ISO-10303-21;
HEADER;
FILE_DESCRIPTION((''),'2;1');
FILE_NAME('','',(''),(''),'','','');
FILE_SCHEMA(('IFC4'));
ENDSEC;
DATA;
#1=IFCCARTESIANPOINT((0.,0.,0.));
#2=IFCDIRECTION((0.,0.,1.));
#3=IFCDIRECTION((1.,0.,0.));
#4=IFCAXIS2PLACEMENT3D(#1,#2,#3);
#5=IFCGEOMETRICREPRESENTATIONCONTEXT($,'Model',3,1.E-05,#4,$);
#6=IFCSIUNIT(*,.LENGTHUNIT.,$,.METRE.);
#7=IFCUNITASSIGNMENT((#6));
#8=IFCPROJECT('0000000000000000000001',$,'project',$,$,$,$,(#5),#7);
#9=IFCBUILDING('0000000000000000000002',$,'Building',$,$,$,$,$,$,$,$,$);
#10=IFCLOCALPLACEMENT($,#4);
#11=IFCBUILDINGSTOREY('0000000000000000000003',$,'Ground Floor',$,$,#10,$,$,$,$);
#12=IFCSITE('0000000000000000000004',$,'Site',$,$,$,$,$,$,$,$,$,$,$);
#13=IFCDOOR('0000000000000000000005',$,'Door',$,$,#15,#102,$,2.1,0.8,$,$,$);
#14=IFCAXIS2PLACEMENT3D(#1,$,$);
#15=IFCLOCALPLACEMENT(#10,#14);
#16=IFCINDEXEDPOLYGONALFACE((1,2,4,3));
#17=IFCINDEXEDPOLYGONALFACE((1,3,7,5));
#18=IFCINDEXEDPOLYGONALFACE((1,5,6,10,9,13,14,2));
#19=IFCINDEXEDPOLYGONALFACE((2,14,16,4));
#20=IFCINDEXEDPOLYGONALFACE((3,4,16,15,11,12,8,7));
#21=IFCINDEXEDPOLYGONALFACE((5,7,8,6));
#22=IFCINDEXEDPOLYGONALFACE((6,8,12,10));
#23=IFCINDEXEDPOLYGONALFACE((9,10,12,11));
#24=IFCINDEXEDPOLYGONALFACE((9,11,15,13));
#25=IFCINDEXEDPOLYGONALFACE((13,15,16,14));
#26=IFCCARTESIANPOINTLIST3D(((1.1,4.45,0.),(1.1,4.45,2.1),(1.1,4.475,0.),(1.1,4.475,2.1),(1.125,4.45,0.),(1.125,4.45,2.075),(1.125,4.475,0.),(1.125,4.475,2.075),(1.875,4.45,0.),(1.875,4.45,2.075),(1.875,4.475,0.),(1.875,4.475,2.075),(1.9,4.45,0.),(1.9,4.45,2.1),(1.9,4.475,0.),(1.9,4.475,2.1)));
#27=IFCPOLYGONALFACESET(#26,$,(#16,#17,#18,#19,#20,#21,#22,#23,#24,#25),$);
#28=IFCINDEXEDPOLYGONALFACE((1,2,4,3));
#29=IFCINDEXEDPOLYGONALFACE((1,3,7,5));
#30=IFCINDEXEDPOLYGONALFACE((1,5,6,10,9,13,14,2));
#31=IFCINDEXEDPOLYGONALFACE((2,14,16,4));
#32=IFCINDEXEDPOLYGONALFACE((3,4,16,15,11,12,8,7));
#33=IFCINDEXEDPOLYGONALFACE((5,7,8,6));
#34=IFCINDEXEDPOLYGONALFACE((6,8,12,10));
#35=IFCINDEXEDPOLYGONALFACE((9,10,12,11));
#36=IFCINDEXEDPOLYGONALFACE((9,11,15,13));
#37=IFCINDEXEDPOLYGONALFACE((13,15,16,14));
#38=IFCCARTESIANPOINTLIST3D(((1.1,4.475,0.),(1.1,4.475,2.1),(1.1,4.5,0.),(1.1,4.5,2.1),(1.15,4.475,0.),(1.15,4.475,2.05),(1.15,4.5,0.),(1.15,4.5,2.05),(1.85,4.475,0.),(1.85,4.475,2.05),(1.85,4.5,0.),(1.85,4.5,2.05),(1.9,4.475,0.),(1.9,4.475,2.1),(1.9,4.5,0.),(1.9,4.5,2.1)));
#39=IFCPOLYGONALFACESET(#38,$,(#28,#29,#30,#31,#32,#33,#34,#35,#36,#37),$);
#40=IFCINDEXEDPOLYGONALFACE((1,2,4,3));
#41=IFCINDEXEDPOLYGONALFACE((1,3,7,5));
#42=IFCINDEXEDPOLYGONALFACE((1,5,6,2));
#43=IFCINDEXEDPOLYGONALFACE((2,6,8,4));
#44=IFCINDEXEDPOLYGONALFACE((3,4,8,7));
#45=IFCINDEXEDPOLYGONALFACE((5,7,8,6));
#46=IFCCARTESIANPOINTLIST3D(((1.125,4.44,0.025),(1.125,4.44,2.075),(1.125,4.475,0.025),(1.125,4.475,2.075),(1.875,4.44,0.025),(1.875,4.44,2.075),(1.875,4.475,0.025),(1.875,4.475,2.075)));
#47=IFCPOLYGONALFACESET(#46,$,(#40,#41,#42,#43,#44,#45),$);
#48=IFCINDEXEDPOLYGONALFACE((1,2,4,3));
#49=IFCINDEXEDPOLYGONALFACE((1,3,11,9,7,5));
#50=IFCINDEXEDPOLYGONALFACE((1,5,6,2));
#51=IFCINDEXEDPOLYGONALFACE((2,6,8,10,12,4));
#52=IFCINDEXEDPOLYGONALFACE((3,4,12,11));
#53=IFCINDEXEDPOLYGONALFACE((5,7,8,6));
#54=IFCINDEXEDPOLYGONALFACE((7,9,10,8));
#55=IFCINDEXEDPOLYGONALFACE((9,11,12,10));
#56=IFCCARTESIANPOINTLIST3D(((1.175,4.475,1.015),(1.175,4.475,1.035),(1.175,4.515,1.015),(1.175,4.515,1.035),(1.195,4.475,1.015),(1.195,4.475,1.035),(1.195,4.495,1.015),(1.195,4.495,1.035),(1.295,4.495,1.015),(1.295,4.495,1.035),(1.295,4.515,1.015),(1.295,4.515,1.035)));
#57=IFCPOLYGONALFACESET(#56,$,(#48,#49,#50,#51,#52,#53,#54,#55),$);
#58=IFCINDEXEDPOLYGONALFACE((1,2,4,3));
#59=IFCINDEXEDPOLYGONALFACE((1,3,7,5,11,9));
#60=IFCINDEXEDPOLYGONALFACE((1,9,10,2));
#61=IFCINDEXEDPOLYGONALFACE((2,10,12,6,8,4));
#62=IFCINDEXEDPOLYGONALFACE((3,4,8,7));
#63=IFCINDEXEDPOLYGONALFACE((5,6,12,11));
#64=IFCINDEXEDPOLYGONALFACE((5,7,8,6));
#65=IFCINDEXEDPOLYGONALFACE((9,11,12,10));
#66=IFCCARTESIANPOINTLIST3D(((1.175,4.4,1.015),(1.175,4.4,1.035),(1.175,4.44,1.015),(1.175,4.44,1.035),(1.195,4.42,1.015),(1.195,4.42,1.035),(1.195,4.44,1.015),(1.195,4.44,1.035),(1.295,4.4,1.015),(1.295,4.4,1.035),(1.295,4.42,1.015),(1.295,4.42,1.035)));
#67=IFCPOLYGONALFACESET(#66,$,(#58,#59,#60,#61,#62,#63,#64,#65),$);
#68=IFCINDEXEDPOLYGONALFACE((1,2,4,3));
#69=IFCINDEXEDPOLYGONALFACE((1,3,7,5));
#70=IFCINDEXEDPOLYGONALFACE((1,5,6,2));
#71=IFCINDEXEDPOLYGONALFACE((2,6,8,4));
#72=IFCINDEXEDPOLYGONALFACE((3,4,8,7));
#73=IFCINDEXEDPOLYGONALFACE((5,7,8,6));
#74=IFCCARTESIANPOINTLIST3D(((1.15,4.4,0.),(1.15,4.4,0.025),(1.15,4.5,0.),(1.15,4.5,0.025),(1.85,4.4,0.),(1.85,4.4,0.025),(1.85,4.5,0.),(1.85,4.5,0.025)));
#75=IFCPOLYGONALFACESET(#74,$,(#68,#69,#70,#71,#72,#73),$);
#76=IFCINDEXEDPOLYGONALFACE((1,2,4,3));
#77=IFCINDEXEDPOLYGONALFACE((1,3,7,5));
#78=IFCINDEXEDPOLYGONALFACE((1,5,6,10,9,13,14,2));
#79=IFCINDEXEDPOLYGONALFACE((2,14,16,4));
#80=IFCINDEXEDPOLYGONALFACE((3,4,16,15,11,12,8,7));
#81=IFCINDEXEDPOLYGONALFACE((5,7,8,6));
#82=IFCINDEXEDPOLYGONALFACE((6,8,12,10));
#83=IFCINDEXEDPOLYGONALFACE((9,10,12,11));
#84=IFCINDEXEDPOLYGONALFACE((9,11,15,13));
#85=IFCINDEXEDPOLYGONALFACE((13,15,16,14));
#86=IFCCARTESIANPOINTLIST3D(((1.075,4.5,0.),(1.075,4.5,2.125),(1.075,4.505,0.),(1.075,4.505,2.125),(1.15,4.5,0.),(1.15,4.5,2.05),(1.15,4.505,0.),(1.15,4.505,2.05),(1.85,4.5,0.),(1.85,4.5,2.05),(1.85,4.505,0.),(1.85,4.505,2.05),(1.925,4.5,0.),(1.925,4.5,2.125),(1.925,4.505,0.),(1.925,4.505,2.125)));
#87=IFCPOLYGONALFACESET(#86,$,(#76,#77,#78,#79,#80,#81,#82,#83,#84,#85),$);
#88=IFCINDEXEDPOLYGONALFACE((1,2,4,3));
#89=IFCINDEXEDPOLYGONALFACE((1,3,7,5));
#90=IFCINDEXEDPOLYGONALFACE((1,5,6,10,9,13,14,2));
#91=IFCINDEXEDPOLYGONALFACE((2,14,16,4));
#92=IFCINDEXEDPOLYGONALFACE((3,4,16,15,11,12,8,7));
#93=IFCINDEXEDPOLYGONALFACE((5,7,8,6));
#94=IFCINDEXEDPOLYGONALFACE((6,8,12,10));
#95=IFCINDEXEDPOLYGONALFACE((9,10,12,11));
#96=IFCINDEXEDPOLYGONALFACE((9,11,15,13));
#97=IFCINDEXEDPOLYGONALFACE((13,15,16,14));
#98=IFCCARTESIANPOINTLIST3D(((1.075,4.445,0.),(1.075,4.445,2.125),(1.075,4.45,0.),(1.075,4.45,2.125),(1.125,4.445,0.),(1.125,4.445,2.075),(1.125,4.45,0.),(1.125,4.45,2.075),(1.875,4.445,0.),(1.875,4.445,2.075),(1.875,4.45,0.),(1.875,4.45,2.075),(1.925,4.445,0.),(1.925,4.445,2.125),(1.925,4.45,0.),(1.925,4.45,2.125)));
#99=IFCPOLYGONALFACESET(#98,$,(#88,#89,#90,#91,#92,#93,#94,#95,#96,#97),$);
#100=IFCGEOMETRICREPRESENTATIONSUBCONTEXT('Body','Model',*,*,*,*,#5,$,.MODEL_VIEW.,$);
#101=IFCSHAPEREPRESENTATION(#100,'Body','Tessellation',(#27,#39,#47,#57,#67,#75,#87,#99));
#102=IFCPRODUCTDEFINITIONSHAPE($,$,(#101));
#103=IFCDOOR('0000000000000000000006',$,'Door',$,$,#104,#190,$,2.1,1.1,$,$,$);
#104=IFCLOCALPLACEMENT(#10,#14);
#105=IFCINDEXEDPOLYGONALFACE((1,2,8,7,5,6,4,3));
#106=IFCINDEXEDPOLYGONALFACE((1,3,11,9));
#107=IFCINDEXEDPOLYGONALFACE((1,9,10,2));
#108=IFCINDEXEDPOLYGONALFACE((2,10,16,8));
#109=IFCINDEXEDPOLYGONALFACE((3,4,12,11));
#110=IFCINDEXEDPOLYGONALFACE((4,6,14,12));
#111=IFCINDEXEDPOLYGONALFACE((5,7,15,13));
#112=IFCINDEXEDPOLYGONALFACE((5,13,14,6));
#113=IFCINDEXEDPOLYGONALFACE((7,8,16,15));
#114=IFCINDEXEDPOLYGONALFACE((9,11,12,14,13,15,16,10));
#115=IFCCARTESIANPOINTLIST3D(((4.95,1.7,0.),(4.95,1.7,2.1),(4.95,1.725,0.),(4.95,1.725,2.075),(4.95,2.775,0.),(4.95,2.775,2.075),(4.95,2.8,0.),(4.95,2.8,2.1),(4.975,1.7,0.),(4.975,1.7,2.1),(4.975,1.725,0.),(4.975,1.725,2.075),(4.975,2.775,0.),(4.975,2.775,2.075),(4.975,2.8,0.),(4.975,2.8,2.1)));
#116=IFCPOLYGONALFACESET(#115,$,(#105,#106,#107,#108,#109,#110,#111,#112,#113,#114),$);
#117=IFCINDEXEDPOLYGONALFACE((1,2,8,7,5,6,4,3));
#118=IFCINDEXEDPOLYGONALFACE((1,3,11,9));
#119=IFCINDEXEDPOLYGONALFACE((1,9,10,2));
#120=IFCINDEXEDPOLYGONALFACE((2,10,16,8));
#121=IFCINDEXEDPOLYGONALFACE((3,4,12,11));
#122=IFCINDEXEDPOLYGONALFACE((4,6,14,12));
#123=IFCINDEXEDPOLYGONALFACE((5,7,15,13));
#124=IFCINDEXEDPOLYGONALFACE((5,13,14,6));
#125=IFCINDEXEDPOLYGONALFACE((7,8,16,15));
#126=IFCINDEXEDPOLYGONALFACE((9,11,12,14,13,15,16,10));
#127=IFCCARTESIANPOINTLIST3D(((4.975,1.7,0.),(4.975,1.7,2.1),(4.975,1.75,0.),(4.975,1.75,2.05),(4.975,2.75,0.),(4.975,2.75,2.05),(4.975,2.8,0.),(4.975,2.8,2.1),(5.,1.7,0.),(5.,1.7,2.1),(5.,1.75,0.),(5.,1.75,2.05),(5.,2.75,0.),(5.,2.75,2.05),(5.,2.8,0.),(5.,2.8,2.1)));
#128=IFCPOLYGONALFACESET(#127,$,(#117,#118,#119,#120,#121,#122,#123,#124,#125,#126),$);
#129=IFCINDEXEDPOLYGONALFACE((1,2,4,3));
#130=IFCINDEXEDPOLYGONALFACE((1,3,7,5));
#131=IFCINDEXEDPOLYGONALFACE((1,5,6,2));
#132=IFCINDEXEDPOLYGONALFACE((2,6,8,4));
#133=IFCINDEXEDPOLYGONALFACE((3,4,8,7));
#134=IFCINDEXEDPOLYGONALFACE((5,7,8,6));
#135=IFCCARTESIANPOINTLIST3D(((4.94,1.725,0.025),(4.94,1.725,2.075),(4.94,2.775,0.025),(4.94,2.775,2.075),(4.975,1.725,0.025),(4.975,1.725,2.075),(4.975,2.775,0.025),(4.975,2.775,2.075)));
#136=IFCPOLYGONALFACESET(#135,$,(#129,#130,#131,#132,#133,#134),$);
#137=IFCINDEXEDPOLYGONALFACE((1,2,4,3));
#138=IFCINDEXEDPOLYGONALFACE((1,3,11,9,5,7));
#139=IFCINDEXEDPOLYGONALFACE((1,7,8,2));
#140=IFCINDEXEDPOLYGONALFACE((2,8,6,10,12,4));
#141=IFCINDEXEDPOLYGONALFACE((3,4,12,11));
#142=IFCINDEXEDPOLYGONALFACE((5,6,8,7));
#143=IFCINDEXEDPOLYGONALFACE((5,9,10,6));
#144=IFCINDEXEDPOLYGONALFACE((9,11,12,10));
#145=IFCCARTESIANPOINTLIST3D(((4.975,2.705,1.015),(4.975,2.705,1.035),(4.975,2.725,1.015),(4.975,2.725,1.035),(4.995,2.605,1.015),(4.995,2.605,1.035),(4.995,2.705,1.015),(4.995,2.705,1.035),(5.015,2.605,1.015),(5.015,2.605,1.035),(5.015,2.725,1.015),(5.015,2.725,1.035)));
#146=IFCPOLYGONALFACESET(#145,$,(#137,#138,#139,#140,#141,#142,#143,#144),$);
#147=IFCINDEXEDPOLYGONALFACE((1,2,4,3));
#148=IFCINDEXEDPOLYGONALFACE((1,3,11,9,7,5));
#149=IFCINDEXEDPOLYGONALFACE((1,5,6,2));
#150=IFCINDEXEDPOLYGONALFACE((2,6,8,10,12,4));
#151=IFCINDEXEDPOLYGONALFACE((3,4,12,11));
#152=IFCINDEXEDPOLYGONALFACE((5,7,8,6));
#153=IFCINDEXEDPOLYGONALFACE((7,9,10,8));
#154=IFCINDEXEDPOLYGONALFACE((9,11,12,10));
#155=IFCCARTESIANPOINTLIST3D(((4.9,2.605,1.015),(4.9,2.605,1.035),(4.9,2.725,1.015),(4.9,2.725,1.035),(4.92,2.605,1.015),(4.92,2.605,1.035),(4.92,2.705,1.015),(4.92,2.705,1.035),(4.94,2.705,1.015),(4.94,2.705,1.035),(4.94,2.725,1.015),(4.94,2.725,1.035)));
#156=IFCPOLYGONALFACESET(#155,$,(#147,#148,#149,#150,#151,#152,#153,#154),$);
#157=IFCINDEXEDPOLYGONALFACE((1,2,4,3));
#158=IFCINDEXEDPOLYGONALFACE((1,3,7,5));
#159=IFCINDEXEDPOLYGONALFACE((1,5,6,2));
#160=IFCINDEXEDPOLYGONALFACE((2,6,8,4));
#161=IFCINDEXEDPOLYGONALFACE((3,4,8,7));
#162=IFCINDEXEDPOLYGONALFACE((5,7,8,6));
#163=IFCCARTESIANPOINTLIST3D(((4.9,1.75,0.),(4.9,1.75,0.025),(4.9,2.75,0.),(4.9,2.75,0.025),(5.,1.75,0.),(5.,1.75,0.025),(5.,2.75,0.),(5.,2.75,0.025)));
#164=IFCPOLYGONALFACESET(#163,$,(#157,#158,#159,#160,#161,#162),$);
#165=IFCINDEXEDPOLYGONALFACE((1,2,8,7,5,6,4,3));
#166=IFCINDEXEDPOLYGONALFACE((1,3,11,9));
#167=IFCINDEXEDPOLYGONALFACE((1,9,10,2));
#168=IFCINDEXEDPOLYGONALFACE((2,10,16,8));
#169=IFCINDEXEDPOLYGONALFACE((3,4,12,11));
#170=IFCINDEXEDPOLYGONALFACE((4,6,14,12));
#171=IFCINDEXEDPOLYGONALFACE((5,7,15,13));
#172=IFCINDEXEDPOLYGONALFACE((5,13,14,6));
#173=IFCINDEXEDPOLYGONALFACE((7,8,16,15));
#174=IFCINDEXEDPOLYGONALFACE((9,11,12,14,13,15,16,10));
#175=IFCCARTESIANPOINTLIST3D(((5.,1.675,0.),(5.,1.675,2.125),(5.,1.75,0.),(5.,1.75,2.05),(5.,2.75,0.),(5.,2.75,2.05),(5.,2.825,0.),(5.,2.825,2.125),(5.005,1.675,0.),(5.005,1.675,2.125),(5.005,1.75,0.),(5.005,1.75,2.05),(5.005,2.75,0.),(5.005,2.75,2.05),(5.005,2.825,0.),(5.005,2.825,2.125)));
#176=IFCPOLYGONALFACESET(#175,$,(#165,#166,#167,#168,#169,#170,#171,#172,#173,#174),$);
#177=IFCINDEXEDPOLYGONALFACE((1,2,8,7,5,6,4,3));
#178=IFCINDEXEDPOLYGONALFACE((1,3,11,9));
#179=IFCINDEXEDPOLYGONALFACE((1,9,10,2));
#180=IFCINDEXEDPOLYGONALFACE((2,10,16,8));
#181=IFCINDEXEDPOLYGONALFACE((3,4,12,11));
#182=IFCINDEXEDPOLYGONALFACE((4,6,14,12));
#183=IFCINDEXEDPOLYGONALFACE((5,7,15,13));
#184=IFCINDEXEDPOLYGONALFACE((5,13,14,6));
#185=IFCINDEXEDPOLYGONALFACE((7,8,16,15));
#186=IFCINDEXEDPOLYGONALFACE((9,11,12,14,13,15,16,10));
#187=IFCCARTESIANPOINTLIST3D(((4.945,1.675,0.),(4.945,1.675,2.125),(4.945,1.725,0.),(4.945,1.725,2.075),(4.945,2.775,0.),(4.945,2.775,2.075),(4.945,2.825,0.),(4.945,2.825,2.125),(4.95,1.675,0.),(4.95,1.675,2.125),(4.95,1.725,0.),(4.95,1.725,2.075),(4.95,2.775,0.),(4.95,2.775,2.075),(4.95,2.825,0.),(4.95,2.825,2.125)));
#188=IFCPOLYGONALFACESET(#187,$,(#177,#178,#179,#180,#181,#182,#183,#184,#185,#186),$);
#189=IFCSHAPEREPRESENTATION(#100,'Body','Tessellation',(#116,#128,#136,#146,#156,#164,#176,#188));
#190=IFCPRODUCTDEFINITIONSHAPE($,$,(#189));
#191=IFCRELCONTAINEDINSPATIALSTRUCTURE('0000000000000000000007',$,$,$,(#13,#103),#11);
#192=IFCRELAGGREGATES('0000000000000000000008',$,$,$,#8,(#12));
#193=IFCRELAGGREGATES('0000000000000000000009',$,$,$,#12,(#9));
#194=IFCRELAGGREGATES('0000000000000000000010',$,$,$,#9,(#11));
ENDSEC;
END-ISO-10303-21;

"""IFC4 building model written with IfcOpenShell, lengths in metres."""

from ifc_helpers import new_model, si_unit, frame, origin_with_axes, place, context, subcontext, project, spatial, line, indexed_curve, outline, extrude, element, save


model = new_model("IFC4")

# Units and contexts
model_context = context("Model", 3, precision=1e-05, world=origin_with_axes())
body_context = subcontext(model_context, "Body", "Model", "MODEL_VIEW")
ifc_project = project(units=[si_unit("LENGTHUNIT", "METRE")], contexts=[model_context])

# Site, building, storey
site = spatial("IfcSite", under=ifc_project, Name="Site")
building = spatial("IfcBuilding", under=site, Name="Building")
storey_placement = place(None, origin_with_axes())
storey = spatial("IfcBuildingStorey", under=building, at=storey_placement, Name="Ground Floor")

# Doors
door_1_placement = place(storey_placement, frame((1.9, 4.5, 0.0), z_axis=(0.0, 0.0, 1.0), x_axis=(-1.0, 0.0, 0.0)))
element("IfcDoor", 1, at=door_1_placement, inside=storey, Name="Door", OverallHeight=2.1, OverallWidth=0.8, context=body_context, shape_type="SweptSolid", body=[
    extrude(outline(indexed_curve([(0.0, 0.0), (0.0, 2.1), (0.8, 2.1), (0.8, 0.0), (0.775, 0.0), (0.775, 2.075), (0.025, 2.075), (0.025, 0.0)], segments=[line(1, 2, 3, 4, 5, 6, 7, 8, 1)])), frame((0.0, 0.025, 0.0), z_axis=(0.0, -1.0, 0.0), x_axis=(1.0, 0.0, 0.0)), (0.0, 0.0, -1.0), 0.025),
    extrude(outline(indexed_curve([(0.0, 0.0), (0.0, 2.1), (0.8, 2.1), (0.8, 0.0), (0.75, 0.0), (0.75, 2.05), (0.05, 2.05), (0.05, 0.0)], segments=[line(1, 2, 3, 4, 5, 6, 7, 8, 1)])), frame((0.0, 0.0, 0.0), z_axis=(0.0, -1.0, 0.0), x_axis=(1.0, 0.0, 0.0)), (0.0, 0.0, -1.0), 0.025),
    extrude(outline(indexed_curve([(0.0, 0.0), (0.75, 0.0), (0.75, 0.035), (0.0, 0.035)], segments=[line(1, 2, 3, 4, 1)])), frame((0.025, 0.025, 0.025), z_axis=(0.0, 0.0, 1.0), x_axis=(1.0, 0.0, 0.0)), (0.0, 0.0, 1.0), 2.05),
    extrude(outline(indexed_curve([(0.0, 0.0), (0.0, -0.04), (-0.12, -0.04), (-0.12, -0.02), (-0.02, -0.02), (-0.02, 0.0)], segments=[line(1, 2, 3, 4, 5, 6, 1)])), frame((0.725, 0.025, 1.015), z_axis=(0.0, 0.0, 1.0), x_axis=(1.0, 0.0, 0.0)), (0.0, 0.0, 1.0), 0.02),
    extrude(outline(indexed_curve([(0.0, 0.0), (0.0, 0.04), (-0.12, 0.04), (-0.12, 0.02), (-0.02, 0.02), (-0.02, 0.0)], segments=[line(1, 2, 3, 4, 5, 6, 1)])), frame((0.725, 0.06, 1.015), z_axis=(0.0, 0.0, 1.0), x_axis=(1.0, 0.0, 0.0)), (0.0, 0.0, 1.0), 0.02),
    extrude(outline(indexed_curve([(0.0, 0.0), (0.7, 0.0), (0.7, 0.1), (0.0, 0.1)], segments=[line(1, 2, 3, 4, 1)])), frame((0.05, 0.0, 0.0), z_axis=(0.0, 0.0, 1.0), x_axis=(1.0, 0.0, 0.0)), (0.0, 0.0, 1.0), 0.025),
    extrude(outline(indexed_curve([(0.0, 0.0), (0.0, 2.125), (0.85, 2.125), (0.85, 0.0), (0.775, 0.0), (0.775, 2.05), (0.075, 2.05), (0.075, 0.0)], segments=[line(1, 2, 3, 4, 5, 6, 7, 8, 1)])), frame((-0.025, -0.005, 0.0), z_axis=(0.0, -1.0, 0.0), x_axis=(1.0, 0.0, 0.0)), (0.0, 0.0, -1.0), 0.005),
    extrude(outline(indexed_curve([(0.0, 0.0), (0.0, 2.125), (0.85, 2.125), (0.85, 0.0), (0.8, 0.0), (0.8, 2.075), (0.05, 2.075), (0.05, 0.0)], segments=[line(1, 2, 3, 4, 5, 6, 7, 8, 1)])), frame((-0.025, 0.05, 0.0), z_axis=(0.0, -1.0, 0.0), x_axis=(1.0, 0.0, 0.0)), (0.0, 0.0, -1.0), 0.005),
])
door_2_placement = place(storey_placement, frame((5.0, 1.7, 0.0), z_axis=(0.0, 0.0, 1.0), x_axis=(0.0, 1.0, 0.0)))
element("IfcDoor", 2, at=door_2_placement, inside=storey, Name="Door", OverallHeight=2.1, OverallWidth=1.1, context=body_context, shape_type="SweptSolid", body=[
    extrude(outline(indexed_curve([(0.0, 0.0), (0.0, 2.1), (1.1, 2.1), (1.1, 0.0), (1.075, 0.0), (1.075, 2.075), (0.025, 2.075), (0.025, 0.0)], segments=[line(1, 2, 3, 4, 5, 6, 7, 8, 1)])), frame((0.0, 0.025, 0.0), z_axis=(0.0, -1.0, 0.0), x_axis=(1.0, 0.0, 0.0)), (0.0, 0.0, -1.0), 0.025),
    extrude(outline(indexed_curve([(0.0, 0.0), (0.0, 2.1), (1.1, 2.1), (1.1, 0.0), (1.05, 0.0), (1.05, 2.05), (0.05, 2.05), (0.05, 0.0)], segments=[line(1, 2, 3, 4, 5, 6, 7, 8, 1)])), frame((0.0, 0.0, 0.0), z_axis=(0.0, -1.0, 0.0), x_axis=(1.0, 0.0, 0.0)), (0.0, 0.0, -1.0), 0.025),
    extrude(outline(indexed_curve([(0.0, 0.0), (1.05, 0.0), (1.05, 0.035), (0.0, 0.035)], segments=[line(1, 2, 3, 4, 1)])), frame((0.025, 0.025, 0.025), z_axis=(0.0, 0.0, 1.0), x_axis=(1.0, 0.0, 0.0)), (0.0, 0.0, 1.0), 2.05),
    extrude(outline(indexed_curve([(0.0, 0.0), (0.0, -0.04), (-0.12, -0.04), (-0.12, -0.02), (-0.02, -0.02), (-0.02, 0.0)], segments=[line(1, 2, 3, 4, 5, 6, 1)])), frame((1.025, 0.025, 1.015), z_axis=(0.0, 0.0, 1.0), x_axis=(1.0, 0.0, 0.0)), (0.0, 0.0, 1.0), 0.02),
    extrude(outline(indexed_curve([(0.0, 0.0), (0.0, 0.04), (-0.12, 0.04), (-0.12, 0.02), (-0.02, 0.02), (-0.02, 0.0)], segments=[line(1, 2, 3, 4, 5, 6, 1)])), frame((1.025, 0.06, 1.015), z_axis=(0.0, 0.0, 1.0), x_axis=(1.0, 0.0, 0.0)), (0.0, 0.0, 1.0), 0.02),
    extrude(outline(indexed_curve([(0.0, 0.0), (1.0, 0.0), (1.0, 0.1), (0.0, 0.1)], segments=[line(1, 2, 3, 4, 1)])), frame((0.05, 0.0, 0.0), z_axis=(0.0, 0.0, 1.0), x_axis=(1.0, 0.0, 0.0)), (0.0, 0.0, 1.0), 0.025),
    extrude(outline(indexed_curve([(0.0, 0.0), (0.0, 2.125), (1.15, 2.125), (1.15, 0.0), (1.075, 0.0), (1.075, 2.05), (0.075, 2.05), (0.075, 0.0)], segments=[line(1, 2, 3, 4, 5, 6, 7, 8, 1)])), frame((-0.025, -0.005, 0.0), z_axis=(0.0, -1.0, 0.0), x_axis=(1.0, 0.0, 0.0)), (0.0, 0.0, -1.0), 0.005),
    extrude(outline(indexed_curve([(0.0, 0.0), (0.0, 2.125), (1.15, 2.125), (1.15, 0.0), (1.1, 0.0), (1.1, 2.075), (0.05, 2.075), (0.05, 0.0)], segments=[line(1, 2, 3, 4, 5, 6, 7, 8, 1)])), frame((-0.025, 0.05, 0.0), z_axis=(0.0, -1.0, 0.0), x_axis=(1.0, 0.0, 0.0)), (0.0, 0.0, -1.0), 0.005),
])

save(model, "model.ifc")
